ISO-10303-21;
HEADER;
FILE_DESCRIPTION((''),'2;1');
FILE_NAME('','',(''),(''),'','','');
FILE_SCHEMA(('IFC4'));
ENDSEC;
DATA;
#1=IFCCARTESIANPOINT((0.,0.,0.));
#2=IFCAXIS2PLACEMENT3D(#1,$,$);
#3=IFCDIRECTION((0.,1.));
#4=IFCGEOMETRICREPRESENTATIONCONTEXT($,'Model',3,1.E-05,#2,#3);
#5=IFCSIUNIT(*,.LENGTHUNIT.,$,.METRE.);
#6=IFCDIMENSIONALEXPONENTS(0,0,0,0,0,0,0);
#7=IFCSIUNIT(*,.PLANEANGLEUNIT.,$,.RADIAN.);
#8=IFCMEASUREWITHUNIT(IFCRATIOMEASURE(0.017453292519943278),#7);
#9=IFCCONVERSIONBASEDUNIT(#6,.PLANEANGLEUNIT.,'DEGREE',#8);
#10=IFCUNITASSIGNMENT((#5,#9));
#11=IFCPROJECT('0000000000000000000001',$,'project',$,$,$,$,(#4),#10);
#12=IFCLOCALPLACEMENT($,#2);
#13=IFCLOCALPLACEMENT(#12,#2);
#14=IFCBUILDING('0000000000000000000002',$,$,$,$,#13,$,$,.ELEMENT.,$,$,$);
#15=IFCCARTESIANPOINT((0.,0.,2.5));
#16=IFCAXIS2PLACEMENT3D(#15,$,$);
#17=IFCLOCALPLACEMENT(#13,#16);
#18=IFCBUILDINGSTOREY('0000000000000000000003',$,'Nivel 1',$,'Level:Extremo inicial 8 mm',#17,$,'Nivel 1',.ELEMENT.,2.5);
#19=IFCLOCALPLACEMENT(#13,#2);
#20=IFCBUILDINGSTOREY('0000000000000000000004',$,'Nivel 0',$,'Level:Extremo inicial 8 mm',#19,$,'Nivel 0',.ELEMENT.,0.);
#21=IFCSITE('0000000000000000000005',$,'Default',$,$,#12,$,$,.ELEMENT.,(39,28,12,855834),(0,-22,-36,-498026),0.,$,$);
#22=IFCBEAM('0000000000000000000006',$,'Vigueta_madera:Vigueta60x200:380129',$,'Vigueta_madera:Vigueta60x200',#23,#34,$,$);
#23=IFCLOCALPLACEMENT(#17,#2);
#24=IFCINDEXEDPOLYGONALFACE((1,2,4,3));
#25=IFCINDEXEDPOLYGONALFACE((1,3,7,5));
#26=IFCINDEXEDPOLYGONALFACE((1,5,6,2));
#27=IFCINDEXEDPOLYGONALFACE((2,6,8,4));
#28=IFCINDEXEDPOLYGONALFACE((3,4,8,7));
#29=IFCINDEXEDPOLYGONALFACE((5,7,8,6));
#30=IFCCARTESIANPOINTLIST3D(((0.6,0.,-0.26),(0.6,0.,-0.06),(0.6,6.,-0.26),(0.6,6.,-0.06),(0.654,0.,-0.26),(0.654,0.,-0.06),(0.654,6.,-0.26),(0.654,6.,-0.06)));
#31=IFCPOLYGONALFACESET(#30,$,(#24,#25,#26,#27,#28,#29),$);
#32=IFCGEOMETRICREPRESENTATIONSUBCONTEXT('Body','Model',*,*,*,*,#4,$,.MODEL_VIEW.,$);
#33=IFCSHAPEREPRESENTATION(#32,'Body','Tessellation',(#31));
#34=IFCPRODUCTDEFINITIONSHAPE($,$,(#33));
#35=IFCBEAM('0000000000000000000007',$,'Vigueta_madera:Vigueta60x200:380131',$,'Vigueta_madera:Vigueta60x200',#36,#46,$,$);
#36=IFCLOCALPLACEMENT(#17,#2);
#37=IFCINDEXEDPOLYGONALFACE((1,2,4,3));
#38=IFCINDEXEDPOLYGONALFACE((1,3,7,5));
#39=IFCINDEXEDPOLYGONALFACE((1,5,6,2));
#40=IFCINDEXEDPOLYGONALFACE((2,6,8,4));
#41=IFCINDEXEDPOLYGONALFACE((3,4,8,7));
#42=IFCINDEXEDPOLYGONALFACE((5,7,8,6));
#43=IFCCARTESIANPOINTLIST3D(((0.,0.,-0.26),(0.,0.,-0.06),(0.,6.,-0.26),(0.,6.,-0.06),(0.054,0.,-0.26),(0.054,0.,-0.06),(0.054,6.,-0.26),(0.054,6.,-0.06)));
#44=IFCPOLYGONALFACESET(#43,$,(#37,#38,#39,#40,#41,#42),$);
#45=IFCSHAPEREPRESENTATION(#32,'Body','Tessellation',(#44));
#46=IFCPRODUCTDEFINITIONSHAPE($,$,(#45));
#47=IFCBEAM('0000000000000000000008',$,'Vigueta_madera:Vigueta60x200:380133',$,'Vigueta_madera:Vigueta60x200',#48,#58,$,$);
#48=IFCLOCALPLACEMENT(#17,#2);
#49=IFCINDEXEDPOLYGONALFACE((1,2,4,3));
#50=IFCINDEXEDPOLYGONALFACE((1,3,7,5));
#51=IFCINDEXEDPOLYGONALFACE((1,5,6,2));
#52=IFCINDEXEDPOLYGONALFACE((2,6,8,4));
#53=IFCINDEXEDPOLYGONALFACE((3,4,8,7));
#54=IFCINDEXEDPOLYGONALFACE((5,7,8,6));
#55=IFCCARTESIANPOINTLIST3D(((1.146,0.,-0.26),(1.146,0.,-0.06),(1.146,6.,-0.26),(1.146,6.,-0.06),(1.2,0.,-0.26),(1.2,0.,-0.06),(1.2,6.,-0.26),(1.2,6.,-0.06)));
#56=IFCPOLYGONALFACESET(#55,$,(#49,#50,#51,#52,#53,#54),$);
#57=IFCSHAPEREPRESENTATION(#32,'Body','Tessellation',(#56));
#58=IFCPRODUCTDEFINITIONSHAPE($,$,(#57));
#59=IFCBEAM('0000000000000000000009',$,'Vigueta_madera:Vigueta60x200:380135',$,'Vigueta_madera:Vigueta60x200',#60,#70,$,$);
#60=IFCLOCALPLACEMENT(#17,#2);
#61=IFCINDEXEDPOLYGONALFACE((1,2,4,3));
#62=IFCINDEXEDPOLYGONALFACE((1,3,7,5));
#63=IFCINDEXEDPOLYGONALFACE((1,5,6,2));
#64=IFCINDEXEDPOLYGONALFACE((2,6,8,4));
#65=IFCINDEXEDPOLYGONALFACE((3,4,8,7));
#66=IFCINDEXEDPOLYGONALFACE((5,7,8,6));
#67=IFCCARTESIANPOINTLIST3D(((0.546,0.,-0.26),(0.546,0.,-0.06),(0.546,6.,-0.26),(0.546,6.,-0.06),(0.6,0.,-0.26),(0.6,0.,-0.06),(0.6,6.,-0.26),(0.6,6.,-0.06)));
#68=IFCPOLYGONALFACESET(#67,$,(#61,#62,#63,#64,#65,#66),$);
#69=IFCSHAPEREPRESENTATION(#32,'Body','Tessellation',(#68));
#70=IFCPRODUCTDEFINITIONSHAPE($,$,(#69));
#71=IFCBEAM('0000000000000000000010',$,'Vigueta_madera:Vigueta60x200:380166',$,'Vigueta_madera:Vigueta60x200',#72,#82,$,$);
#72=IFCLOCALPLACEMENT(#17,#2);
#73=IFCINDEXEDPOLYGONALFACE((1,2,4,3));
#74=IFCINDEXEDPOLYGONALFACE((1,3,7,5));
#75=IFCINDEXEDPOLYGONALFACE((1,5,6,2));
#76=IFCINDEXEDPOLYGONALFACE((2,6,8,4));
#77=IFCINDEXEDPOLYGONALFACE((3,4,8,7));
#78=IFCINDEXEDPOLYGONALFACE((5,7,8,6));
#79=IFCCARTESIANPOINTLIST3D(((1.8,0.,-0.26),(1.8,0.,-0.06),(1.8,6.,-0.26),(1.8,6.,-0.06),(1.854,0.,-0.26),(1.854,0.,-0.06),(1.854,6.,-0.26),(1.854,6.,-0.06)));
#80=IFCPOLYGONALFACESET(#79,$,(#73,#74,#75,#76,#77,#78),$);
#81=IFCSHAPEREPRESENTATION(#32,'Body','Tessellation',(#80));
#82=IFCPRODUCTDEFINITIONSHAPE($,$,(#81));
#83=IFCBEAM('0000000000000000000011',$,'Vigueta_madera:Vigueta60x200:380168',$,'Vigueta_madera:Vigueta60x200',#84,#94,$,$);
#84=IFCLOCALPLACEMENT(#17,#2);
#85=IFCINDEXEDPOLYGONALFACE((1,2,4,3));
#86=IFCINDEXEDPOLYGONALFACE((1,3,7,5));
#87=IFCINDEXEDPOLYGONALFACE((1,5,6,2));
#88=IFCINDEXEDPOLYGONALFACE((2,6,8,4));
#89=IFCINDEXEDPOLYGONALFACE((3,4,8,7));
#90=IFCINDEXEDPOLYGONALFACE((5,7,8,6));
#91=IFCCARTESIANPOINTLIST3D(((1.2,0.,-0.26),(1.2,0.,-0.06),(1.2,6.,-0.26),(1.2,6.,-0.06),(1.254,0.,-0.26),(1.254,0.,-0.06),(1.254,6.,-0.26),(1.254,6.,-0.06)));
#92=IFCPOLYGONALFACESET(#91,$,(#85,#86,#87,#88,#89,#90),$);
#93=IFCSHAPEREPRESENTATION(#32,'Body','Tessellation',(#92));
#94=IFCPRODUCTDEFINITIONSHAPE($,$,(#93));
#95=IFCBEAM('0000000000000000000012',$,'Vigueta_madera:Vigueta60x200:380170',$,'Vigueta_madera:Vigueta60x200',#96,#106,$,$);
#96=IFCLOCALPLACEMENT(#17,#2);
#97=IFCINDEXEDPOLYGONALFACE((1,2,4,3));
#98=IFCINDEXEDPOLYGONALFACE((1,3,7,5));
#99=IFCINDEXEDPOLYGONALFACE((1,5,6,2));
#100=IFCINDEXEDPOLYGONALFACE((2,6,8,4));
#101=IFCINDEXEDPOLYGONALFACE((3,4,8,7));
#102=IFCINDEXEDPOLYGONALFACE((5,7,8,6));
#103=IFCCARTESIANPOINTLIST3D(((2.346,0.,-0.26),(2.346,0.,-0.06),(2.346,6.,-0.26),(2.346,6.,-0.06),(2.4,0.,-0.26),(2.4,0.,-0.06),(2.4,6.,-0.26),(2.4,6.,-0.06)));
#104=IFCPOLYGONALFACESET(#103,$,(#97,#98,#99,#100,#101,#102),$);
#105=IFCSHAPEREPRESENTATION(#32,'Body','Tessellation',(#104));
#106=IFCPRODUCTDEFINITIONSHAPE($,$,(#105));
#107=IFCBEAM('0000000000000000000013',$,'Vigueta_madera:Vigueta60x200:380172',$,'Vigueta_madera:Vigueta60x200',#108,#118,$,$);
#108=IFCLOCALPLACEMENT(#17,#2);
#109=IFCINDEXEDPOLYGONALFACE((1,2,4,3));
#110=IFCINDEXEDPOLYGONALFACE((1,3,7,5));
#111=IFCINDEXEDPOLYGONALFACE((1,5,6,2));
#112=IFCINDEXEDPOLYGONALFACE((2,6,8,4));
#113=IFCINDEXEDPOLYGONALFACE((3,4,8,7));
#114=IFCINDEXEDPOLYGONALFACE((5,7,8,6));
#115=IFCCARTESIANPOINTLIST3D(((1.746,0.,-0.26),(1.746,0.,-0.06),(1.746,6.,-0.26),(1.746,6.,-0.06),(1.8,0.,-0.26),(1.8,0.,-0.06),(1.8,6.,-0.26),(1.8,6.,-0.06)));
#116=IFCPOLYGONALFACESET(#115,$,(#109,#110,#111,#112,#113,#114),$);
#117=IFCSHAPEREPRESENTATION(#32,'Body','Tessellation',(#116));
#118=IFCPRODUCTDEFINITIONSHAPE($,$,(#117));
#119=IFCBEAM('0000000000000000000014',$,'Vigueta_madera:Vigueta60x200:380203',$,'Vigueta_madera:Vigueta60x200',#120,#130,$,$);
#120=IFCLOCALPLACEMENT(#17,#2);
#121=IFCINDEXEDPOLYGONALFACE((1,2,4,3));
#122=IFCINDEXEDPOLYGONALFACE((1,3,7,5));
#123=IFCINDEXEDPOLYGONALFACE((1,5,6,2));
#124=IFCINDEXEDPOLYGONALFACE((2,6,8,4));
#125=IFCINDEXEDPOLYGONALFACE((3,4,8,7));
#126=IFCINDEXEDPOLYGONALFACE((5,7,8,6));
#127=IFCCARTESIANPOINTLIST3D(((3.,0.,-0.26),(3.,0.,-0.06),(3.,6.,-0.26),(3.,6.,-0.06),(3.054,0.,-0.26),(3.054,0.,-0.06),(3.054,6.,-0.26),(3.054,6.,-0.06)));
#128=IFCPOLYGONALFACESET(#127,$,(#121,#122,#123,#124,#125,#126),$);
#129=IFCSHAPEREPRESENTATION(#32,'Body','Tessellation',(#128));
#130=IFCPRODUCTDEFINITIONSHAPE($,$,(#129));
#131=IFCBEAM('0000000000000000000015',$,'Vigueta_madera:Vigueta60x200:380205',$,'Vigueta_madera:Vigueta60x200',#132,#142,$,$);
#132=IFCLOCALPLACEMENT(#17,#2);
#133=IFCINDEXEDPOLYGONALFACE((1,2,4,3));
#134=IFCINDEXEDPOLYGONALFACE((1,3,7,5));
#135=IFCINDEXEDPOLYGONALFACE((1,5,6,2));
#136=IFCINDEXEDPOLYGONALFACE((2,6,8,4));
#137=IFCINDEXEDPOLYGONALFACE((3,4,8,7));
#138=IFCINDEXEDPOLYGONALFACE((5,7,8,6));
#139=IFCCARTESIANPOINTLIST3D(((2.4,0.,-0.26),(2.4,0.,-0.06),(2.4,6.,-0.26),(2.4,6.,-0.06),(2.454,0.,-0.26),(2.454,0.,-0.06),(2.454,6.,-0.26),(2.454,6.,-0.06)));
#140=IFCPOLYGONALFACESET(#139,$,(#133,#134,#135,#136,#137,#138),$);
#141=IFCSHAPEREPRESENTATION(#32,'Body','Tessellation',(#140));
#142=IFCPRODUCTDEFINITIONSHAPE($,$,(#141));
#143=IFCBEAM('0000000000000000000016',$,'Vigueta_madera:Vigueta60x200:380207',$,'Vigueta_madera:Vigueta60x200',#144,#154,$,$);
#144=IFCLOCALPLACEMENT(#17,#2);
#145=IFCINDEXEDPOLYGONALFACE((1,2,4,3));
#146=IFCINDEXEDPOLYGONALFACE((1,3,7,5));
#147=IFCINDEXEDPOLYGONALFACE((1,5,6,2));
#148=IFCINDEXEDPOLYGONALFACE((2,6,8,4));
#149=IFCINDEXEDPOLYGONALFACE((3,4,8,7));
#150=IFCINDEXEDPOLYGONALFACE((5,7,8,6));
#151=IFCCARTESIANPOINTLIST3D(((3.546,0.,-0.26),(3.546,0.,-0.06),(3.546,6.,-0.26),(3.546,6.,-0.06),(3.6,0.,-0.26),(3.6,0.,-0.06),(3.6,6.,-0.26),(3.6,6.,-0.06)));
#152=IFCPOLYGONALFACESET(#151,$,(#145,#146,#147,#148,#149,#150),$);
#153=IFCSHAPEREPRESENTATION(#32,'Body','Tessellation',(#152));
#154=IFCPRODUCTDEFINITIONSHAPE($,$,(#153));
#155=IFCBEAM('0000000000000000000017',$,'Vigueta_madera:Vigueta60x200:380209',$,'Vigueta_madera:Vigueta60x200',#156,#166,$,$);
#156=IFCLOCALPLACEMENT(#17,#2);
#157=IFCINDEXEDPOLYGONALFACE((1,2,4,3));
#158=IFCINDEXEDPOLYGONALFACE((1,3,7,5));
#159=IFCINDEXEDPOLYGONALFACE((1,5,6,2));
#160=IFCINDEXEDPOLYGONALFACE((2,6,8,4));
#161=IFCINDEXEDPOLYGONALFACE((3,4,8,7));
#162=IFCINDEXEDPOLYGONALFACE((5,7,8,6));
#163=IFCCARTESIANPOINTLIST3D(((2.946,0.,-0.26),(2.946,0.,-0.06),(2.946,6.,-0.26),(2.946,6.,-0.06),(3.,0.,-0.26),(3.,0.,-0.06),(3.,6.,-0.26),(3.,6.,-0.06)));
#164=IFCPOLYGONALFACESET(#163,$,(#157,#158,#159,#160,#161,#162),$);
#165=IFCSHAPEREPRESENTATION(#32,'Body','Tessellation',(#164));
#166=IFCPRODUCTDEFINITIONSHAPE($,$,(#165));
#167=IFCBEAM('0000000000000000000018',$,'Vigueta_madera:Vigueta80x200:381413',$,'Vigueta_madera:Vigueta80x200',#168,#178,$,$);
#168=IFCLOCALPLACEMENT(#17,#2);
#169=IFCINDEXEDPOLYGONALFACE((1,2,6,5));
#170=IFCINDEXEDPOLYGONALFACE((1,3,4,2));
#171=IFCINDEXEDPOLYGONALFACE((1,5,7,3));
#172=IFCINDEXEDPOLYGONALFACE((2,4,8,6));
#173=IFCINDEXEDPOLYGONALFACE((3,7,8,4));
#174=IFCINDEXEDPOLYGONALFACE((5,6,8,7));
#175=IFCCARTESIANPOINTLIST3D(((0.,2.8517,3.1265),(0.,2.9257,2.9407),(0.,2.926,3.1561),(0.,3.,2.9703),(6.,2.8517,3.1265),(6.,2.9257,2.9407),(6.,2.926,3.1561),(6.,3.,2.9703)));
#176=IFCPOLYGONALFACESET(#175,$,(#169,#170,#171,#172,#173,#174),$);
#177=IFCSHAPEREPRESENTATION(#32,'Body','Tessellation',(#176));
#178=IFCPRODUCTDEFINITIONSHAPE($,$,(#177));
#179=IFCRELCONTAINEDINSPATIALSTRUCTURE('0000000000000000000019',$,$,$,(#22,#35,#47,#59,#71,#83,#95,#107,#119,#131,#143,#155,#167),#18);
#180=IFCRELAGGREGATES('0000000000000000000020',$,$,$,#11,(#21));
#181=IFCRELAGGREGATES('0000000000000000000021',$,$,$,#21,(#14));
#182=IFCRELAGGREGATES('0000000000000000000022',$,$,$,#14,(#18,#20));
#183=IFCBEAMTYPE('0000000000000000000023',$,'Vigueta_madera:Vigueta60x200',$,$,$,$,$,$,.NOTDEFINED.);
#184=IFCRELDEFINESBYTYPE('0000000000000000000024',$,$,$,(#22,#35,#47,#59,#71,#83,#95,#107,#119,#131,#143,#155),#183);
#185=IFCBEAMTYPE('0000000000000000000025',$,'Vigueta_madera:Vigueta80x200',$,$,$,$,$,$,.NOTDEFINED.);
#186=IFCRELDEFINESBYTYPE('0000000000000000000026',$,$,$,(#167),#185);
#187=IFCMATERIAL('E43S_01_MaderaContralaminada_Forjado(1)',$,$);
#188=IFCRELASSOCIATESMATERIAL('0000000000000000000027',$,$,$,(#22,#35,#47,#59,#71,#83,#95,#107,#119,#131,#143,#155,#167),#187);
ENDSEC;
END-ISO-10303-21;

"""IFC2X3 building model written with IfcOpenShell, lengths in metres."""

from ifc_helpers import new_model, entity, si_unit, converted_unit, direction, frame, frame_2d, origin, place, context, subcontext, project, spatial, rectangle, extrude, material, type_object, element, save


model = new_model("IFC2X3")

# Units and contexts
model_context = context("Model", 3, precision=1e-05, world=origin(), true_north=direction((0.0, 1.0)))
body_context = subcontext(model_context, "Body", "Model", "MODEL_VIEW")
ifc_project = project(units=[si_unit("LENGTHUNIT", "METRE"), converted_unit("PLANEANGLEUNIT", "DEGREE", entity("IfcRatioMeasure", 0.017453292519943278), si_unit("PLANEANGLEUNIT", "RADIAN"), dimensions=[0, 0, 0, 0, 0, 0, 0])], contexts=[model_context])

# Site, building, storey
site_placement = place(None, origin())
site = spatial("IfcSite", under=ifc_project, at=site_placement, Name="Default", CompositionType="ELEMENT", RefLatitude=(39, 28, 12, 855834), RefLongitude=(0, -22, -36, -498026), RefElevation=0.0)
building_placement = place(site_placement, origin())
building = spatial("IfcBuilding", under=site, at=building_placement, CompositionType="ELEMENT")
storey_1_placement = place(building_placement, frame((0.0, 0.0, 2.5)))
storey_1 = spatial("IfcBuildingStorey", under=building, at=storey_1_placement, Name="Nivel 1", ObjectType="Level:Extremo inicial 8 mm", LongName="Nivel 1", CompositionType="ELEMENT", Elevation=2.5)

# Beams
ifc_material_1 = material(Name="E43S_01_MaderaContralaminada_Forjado(1)")
beam_type_1 = type_object("IfcBeamType", Name="Vigueta_madera:Vigueta60x200", PredefinedType="NOTDEFINED")
beam_1_placement = place(storey_1_placement, frame((0.627, 0.0, -0.06), z_axis=(0.0, 0.0, 1.0), x_axis=(0.0, 1.0, 0.0)))
element("IfcBeam", 1, at=beam_1_placement, inside=storey_1, type_object=beam_type_1, material=ifc_material_1, Name="Vigueta_madera:Vigueta60x200:380129", ObjectType="Vigueta_madera:Vigueta60x200", context=body_context, shape_type="SweptSolid", body=[
    extrude(rectangle(XDim=0.2, YDim=0.054, at=frame_2d((0.0, 0.0), x_axis=(1.0, 0.0))), frame((0.0, 0.0, -0.1), z_axis=(1.0, 0.0, 0.0), x_axis=(0.0, 0.0, -1.0)), (0.0, 0.0, 1.0), 6.0),
])
beam_2_placement = place(storey_1_placement, frame((0.027, 0.0, -0.06), z_axis=(0.0, 0.0, 1.0), x_axis=(0.0, 1.0, 0.0)))
element("IfcBeam", 2, at=beam_2_placement, inside=storey_1, type_object=beam_type_1, material=ifc_material_1, Name="Vigueta_madera:Vigueta60x200:380131", ObjectType="Vigueta_madera:Vigueta60x200", context=body_context, shape_type="SweptSolid", body=[
    extrude(rectangle(XDim=0.2, YDim=0.054, at=frame_2d((0.0, 0.0), x_axis=(1.0, 0.0))), frame((0.0, 0.0, -0.1), z_axis=(1.0, 0.0, 0.0), x_axis=(0.0, 0.0, -1.0)), (0.0, 0.0, 1.0), 6.0),
])
beam_3_placement = place(storey_1_placement, frame((1.173, 0.0, -0.06), z_axis=(0.0, 0.0, 1.0), x_axis=(0.0, 1.0, 0.0)))
element("IfcBeam", 3, at=beam_3_placement, inside=storey_1, type_object=beam_type_1, material=ifc_material_1, Name="Vigueta_madera:Vigueta60x200:380133", ObjectType="Vigueta_madera:Vigueta60x200", context=body_context, shape_type="SweptSolid", body=[
    extrude(rectangle(XDim=0.2, YDim=0.054, at=frame_2d((0.0, 0.0), x_axis=(1.0, 0.0))), frame((0.0, 0.0, -0.1), z_axis=(1.0, 0.0, 0.0), x_axis=(0.0, 0.0, -1.0)), (0.0, 0.0, 1.0), 6.0),
])
beam_4_placement = place(storey_1_placement, frame((0.573, 0.0, -0.06), z_axis=(0.0, 0.0, 1.0), x_axis=(0.0, 1.0, 0.0)))
element("IfcBeam", 4, at=beam_4_placement, inside=storey_1, type_object=beam_type_1, material=ifc_material_1, Name="Vigueta_madera:Vigueta60x200:380135", ObjectType="Vigueta_madera:Vigueta60x200", context=body_context, shape_type="SweptSolid", body=[
    extrude(rectangle(XDim=0.2, YDim=0.054, at=frame_2d((0.0, 0.0), x_axis=(1.0, 0.0))), frame((0.0, 0.0, -0.1), z_axis=(1.0, 0.0, 0.0), x_axis=(0.0, 0.0, -1.0)), (0.0, 0.0, 1.0), 6.0),
])
beam_5_placement = place(storey_1_placement, frame((1.827, 0.0, -0.06), z_axis=(0.0, 0.0, 1.0), x_axis=(0.0, 1.0, 0.0)))
element("IfcBeam", 5, at=beam_5_placement, inside=storey_1, type_object=beam_type_1, material=ifc_material_1, Name="Vigueta_madera:Vigueta60x200:380166", ObjectType="Vigueta_madera:Vigueta60x200", context=body_context, shape_type="SweptSolid", body=[
    extrude(rectangle(XDim=0.2, YDim=0.054, at=frame_2d((0.0, 0.0), x_axis=(1.0, 0.0))), frame((0.0, 0.0, -0.1), z_axis=(1.0, 0.0, 0.0), x_axis=(0.0, 0.0, -1.0)), (0.0, 0.0, 1.0), 6.0),
])
beam_6_placement = place(storey_1_placement, frame((1.227, 0.0, -0.06), z_axis=(0.0, 0.0, 1.0), x_axis=(0.0, 1.0, 0.0)))
element("IfcBeam", 6, at=beam_6_placement, inside=storey_1, type_object=beam_type_1, material=ifc_material_1, Name="Vigueta_madera:Vigueta60x200:380168", ObjectType="Vigueta_madera:Vigueta60x200", context=body_context, shape_type="SweptSolid", body=[
    extrude(rectangle(XDim=0.2, YDim=0.054, at=frame_2d((0.0, 0.0), x_axis=(1.0, 0.0))), frame((0.0, 0.0, -0.1), z_axis=(1.0, 0.0, 0.0), x_axis=(0.0, 0.0, -1.0)), (0.0, 0.0, 1.0), 6.0),
])
beam_7_placement = place(storey_1_placement, frame((2.373, 0.0, -0.06), z_axis=(0.0, 0.0, 1.0), x_axis=(0.0, 1.0, 0.0)))
element("IfcBeam", 7, at=beam_7_placement, inside=storey_1, type_object=beam_type_1, material=ifc_material_1, Name="Vigueta_madera:Vigueta60x200:380170", ObjectType="Vigueta_madera:Vigueta60x200", context=body_context, shape_type="SweptSolid", body=[
    extrude(rectangle(XDim=0.2, YDim=0.054, at=frame_2d((0.0, 0.0), x_axis=(1.0, 0.0))), frame((0.0, 0.0, -0.1), z_axis=(1.0, 0.0, 0.0), x_axis=(0.0, 0.0, -1.0)), (0.0, 0.0, 1.0), 6.0),
])
beam_8_placement = place(storey_1_placement, frame((1.773, 0.0, -0.06), z_axis=(0.0, 0.0, 1.0), x_axis=(0.0, 1.0, 0.0)))
element("IfcBeam", 8, at=beam_8_placement, inside=storey_1, type_object=beam_type_1, material=ifc_material_1, Name="Vigueta_madera:Vigueta60x200:380172", ObjectType="Vigueta_madera:Vigueta60x200", context=body_context, shape_type="SweptSolid", body=[
    extrude(rectangle(XDim=0.2, YDim=0.054, at=frame_2d((0.0, 0.0), x_axis=(1.0, 0.0))), frame((0.0, 0.0, -0.1), z_axis=(1.0, 0.0, 0.0), x_axis=(0.0, 0.0, -1.0)), (0.0, 0.0, 1.0), 6.0),
])
beam_9_placement = place(storey_1_placement, frame((3.027, 0.0, -0.06), z_axis=(0.0, 0.0, 1.0), x_axis=(0.0, 1.0, 0.0)))
element("IfcBeam", 9, at=beam_9_placement, inside=storey_1, type_object=beam_type_1, material=ifc_material_1, Name="Vigueta_madera:Vigueta60x200:380203", ObjectType="Vigueta_madera:Vigueta60x200", context=body_context, shape_type="SweptSolid", body=[
    extrude(rectangle(XDim=0.2, YDim=0.054, at=frame_2d((0.0, 0.0), x_axis=(1.0, 0.0))), frame((0.0, 0.0, -0.1), z_axis=(1.0, 0.0, 0.0), x_axis=(0.0, 0.0, -1.0)), (0.0, 0.0, 1.0), 6.0),
])
beam_10_placement = place(storey_1_placement, frame((2.427, 0.0, -0.06), z_axis=(0.0, 0.0, 1.0), x_axis=(0.0, 1.0, 0.0)))
element("IfcBeam", 10, at=beam_10_placement, inside=storey_1, type_object=beam_type_1, material=ifc_material_1, Name="Vigueta_madera:Vigueta60x200:380205", ObjectType="Vigueta_madera:Vigueta60x200", context=body_context, shape_type="SweptSolid", body=[
    extrude(rectangle(XDim=0.2, YDim=0.054, at=frame_2d((0.0, 0.0), x_axis=(1.0, 0.0))), frame((0.0, 0.0, -0.1), z_axis=(1.0, 0.0, 0.0), x_axis=(0.0, 0.0, -1.0)), (0.0, 0.0, 1.0), 6.0),
])
beam_11_placement = place(storey_1_placement, frame((3.573, 0.0, -0.06), z_axis=(0.0, 0.0, 1.0), x_axis=(0.0, 1.0, 0.0)))
element("IfcBeam", 11, at=beam_11_placement, inside=storey_1, type_object=beam_type_1, material=ifc_material_1, Name="Vigueta_madera:Vigueta60x200:380207", ObjectType="Vigueta_madera:Vigueta60x200", context=body_context, shape_type="SweptSolid", body=[
    extrude(rectangle(XDim=0.2, YDim=0.054, at=frame_2d((0.0, 0.0), x_axis=(1.0, 0.0))), frame((0.0, 0.0, -0.1), z_axis=(1.0, 0.0, 0.0), x_axis=(0.0, 0.0, -1.0)), (0.0, 0.0, 1.0), 6.0),
])
beam_12_placement = place(storey_1_placement, frame((2.973, 0.0, -0.06), z_axis=(0.0, 0.0, 1.0), x_axis=(0.0, 1.0, 0.0)))
element("IfcBeam", 12, at=beam_12_placement, inside=storey_1, type_object=beam_type_1, material=ifc_material_1, Name="Vigueta_madera:Vigueta60x200:380209", ObjectType="Vigueta_madera:Vigueta60x200", context=body_context, shape_type="SweptSolid", body=[
    extrude(rectangle(XDim=0.2, YDim=0.054, at=frame_2d((0.0, 0.0), x_axis=(1.0, 0.0))), frame((0.0, 0.0, -0.1), z_axis=(1.0, 0.0, 0.0), x_axis=(0.0, 0.0, -1.0)), (0.0, 0.0, 1.0), 6.0),
])
beam_type_2 = type_object("IfcBeamType", Name="Vigueta_madera:Vigueta80x200", PredefinedType="NOTDEFINED")
beam_13_placement = place(storey_1_placement, frame((0.0, 2.8888, 3.1413)))
element("IfcBeam", 13, at=beam_13_placement, inside=storey_1, type_object=beam_type_2, material=ifc_material_1, Name="Vigueta_madera:Vigueta80x200:381413", ObjectType="Vigueta_madera:Vigueta80x200", context=body_context, shape_type="SweptSolid", body=[
    extrude(rectangle(XDim=0.2, YDim=0.08, at=frame_2d((0.0, 0.0), x_axis=(1.0, 0.0))), frame((0.0, 0.037, -0.0929), z_axis=(1.0, 0.0, 0.0), x_axis=(0.0, -0.370233, 0.928939)), (0.0, 0.0, 1.0), 6.0),
])

# Shared definitions
storey_2_placement = place(building_placement, origin())
storey_2 = spatial("IfcBuildingStorey", under=building, at=storey_2_placement, Name="Nivel 0", ObjectType="Level:Extremo inicial 8 mm", LongName="Nivel 0", CompositionType="ELEMENT", Elevation=0.0)

save(model, "model.ifc")
